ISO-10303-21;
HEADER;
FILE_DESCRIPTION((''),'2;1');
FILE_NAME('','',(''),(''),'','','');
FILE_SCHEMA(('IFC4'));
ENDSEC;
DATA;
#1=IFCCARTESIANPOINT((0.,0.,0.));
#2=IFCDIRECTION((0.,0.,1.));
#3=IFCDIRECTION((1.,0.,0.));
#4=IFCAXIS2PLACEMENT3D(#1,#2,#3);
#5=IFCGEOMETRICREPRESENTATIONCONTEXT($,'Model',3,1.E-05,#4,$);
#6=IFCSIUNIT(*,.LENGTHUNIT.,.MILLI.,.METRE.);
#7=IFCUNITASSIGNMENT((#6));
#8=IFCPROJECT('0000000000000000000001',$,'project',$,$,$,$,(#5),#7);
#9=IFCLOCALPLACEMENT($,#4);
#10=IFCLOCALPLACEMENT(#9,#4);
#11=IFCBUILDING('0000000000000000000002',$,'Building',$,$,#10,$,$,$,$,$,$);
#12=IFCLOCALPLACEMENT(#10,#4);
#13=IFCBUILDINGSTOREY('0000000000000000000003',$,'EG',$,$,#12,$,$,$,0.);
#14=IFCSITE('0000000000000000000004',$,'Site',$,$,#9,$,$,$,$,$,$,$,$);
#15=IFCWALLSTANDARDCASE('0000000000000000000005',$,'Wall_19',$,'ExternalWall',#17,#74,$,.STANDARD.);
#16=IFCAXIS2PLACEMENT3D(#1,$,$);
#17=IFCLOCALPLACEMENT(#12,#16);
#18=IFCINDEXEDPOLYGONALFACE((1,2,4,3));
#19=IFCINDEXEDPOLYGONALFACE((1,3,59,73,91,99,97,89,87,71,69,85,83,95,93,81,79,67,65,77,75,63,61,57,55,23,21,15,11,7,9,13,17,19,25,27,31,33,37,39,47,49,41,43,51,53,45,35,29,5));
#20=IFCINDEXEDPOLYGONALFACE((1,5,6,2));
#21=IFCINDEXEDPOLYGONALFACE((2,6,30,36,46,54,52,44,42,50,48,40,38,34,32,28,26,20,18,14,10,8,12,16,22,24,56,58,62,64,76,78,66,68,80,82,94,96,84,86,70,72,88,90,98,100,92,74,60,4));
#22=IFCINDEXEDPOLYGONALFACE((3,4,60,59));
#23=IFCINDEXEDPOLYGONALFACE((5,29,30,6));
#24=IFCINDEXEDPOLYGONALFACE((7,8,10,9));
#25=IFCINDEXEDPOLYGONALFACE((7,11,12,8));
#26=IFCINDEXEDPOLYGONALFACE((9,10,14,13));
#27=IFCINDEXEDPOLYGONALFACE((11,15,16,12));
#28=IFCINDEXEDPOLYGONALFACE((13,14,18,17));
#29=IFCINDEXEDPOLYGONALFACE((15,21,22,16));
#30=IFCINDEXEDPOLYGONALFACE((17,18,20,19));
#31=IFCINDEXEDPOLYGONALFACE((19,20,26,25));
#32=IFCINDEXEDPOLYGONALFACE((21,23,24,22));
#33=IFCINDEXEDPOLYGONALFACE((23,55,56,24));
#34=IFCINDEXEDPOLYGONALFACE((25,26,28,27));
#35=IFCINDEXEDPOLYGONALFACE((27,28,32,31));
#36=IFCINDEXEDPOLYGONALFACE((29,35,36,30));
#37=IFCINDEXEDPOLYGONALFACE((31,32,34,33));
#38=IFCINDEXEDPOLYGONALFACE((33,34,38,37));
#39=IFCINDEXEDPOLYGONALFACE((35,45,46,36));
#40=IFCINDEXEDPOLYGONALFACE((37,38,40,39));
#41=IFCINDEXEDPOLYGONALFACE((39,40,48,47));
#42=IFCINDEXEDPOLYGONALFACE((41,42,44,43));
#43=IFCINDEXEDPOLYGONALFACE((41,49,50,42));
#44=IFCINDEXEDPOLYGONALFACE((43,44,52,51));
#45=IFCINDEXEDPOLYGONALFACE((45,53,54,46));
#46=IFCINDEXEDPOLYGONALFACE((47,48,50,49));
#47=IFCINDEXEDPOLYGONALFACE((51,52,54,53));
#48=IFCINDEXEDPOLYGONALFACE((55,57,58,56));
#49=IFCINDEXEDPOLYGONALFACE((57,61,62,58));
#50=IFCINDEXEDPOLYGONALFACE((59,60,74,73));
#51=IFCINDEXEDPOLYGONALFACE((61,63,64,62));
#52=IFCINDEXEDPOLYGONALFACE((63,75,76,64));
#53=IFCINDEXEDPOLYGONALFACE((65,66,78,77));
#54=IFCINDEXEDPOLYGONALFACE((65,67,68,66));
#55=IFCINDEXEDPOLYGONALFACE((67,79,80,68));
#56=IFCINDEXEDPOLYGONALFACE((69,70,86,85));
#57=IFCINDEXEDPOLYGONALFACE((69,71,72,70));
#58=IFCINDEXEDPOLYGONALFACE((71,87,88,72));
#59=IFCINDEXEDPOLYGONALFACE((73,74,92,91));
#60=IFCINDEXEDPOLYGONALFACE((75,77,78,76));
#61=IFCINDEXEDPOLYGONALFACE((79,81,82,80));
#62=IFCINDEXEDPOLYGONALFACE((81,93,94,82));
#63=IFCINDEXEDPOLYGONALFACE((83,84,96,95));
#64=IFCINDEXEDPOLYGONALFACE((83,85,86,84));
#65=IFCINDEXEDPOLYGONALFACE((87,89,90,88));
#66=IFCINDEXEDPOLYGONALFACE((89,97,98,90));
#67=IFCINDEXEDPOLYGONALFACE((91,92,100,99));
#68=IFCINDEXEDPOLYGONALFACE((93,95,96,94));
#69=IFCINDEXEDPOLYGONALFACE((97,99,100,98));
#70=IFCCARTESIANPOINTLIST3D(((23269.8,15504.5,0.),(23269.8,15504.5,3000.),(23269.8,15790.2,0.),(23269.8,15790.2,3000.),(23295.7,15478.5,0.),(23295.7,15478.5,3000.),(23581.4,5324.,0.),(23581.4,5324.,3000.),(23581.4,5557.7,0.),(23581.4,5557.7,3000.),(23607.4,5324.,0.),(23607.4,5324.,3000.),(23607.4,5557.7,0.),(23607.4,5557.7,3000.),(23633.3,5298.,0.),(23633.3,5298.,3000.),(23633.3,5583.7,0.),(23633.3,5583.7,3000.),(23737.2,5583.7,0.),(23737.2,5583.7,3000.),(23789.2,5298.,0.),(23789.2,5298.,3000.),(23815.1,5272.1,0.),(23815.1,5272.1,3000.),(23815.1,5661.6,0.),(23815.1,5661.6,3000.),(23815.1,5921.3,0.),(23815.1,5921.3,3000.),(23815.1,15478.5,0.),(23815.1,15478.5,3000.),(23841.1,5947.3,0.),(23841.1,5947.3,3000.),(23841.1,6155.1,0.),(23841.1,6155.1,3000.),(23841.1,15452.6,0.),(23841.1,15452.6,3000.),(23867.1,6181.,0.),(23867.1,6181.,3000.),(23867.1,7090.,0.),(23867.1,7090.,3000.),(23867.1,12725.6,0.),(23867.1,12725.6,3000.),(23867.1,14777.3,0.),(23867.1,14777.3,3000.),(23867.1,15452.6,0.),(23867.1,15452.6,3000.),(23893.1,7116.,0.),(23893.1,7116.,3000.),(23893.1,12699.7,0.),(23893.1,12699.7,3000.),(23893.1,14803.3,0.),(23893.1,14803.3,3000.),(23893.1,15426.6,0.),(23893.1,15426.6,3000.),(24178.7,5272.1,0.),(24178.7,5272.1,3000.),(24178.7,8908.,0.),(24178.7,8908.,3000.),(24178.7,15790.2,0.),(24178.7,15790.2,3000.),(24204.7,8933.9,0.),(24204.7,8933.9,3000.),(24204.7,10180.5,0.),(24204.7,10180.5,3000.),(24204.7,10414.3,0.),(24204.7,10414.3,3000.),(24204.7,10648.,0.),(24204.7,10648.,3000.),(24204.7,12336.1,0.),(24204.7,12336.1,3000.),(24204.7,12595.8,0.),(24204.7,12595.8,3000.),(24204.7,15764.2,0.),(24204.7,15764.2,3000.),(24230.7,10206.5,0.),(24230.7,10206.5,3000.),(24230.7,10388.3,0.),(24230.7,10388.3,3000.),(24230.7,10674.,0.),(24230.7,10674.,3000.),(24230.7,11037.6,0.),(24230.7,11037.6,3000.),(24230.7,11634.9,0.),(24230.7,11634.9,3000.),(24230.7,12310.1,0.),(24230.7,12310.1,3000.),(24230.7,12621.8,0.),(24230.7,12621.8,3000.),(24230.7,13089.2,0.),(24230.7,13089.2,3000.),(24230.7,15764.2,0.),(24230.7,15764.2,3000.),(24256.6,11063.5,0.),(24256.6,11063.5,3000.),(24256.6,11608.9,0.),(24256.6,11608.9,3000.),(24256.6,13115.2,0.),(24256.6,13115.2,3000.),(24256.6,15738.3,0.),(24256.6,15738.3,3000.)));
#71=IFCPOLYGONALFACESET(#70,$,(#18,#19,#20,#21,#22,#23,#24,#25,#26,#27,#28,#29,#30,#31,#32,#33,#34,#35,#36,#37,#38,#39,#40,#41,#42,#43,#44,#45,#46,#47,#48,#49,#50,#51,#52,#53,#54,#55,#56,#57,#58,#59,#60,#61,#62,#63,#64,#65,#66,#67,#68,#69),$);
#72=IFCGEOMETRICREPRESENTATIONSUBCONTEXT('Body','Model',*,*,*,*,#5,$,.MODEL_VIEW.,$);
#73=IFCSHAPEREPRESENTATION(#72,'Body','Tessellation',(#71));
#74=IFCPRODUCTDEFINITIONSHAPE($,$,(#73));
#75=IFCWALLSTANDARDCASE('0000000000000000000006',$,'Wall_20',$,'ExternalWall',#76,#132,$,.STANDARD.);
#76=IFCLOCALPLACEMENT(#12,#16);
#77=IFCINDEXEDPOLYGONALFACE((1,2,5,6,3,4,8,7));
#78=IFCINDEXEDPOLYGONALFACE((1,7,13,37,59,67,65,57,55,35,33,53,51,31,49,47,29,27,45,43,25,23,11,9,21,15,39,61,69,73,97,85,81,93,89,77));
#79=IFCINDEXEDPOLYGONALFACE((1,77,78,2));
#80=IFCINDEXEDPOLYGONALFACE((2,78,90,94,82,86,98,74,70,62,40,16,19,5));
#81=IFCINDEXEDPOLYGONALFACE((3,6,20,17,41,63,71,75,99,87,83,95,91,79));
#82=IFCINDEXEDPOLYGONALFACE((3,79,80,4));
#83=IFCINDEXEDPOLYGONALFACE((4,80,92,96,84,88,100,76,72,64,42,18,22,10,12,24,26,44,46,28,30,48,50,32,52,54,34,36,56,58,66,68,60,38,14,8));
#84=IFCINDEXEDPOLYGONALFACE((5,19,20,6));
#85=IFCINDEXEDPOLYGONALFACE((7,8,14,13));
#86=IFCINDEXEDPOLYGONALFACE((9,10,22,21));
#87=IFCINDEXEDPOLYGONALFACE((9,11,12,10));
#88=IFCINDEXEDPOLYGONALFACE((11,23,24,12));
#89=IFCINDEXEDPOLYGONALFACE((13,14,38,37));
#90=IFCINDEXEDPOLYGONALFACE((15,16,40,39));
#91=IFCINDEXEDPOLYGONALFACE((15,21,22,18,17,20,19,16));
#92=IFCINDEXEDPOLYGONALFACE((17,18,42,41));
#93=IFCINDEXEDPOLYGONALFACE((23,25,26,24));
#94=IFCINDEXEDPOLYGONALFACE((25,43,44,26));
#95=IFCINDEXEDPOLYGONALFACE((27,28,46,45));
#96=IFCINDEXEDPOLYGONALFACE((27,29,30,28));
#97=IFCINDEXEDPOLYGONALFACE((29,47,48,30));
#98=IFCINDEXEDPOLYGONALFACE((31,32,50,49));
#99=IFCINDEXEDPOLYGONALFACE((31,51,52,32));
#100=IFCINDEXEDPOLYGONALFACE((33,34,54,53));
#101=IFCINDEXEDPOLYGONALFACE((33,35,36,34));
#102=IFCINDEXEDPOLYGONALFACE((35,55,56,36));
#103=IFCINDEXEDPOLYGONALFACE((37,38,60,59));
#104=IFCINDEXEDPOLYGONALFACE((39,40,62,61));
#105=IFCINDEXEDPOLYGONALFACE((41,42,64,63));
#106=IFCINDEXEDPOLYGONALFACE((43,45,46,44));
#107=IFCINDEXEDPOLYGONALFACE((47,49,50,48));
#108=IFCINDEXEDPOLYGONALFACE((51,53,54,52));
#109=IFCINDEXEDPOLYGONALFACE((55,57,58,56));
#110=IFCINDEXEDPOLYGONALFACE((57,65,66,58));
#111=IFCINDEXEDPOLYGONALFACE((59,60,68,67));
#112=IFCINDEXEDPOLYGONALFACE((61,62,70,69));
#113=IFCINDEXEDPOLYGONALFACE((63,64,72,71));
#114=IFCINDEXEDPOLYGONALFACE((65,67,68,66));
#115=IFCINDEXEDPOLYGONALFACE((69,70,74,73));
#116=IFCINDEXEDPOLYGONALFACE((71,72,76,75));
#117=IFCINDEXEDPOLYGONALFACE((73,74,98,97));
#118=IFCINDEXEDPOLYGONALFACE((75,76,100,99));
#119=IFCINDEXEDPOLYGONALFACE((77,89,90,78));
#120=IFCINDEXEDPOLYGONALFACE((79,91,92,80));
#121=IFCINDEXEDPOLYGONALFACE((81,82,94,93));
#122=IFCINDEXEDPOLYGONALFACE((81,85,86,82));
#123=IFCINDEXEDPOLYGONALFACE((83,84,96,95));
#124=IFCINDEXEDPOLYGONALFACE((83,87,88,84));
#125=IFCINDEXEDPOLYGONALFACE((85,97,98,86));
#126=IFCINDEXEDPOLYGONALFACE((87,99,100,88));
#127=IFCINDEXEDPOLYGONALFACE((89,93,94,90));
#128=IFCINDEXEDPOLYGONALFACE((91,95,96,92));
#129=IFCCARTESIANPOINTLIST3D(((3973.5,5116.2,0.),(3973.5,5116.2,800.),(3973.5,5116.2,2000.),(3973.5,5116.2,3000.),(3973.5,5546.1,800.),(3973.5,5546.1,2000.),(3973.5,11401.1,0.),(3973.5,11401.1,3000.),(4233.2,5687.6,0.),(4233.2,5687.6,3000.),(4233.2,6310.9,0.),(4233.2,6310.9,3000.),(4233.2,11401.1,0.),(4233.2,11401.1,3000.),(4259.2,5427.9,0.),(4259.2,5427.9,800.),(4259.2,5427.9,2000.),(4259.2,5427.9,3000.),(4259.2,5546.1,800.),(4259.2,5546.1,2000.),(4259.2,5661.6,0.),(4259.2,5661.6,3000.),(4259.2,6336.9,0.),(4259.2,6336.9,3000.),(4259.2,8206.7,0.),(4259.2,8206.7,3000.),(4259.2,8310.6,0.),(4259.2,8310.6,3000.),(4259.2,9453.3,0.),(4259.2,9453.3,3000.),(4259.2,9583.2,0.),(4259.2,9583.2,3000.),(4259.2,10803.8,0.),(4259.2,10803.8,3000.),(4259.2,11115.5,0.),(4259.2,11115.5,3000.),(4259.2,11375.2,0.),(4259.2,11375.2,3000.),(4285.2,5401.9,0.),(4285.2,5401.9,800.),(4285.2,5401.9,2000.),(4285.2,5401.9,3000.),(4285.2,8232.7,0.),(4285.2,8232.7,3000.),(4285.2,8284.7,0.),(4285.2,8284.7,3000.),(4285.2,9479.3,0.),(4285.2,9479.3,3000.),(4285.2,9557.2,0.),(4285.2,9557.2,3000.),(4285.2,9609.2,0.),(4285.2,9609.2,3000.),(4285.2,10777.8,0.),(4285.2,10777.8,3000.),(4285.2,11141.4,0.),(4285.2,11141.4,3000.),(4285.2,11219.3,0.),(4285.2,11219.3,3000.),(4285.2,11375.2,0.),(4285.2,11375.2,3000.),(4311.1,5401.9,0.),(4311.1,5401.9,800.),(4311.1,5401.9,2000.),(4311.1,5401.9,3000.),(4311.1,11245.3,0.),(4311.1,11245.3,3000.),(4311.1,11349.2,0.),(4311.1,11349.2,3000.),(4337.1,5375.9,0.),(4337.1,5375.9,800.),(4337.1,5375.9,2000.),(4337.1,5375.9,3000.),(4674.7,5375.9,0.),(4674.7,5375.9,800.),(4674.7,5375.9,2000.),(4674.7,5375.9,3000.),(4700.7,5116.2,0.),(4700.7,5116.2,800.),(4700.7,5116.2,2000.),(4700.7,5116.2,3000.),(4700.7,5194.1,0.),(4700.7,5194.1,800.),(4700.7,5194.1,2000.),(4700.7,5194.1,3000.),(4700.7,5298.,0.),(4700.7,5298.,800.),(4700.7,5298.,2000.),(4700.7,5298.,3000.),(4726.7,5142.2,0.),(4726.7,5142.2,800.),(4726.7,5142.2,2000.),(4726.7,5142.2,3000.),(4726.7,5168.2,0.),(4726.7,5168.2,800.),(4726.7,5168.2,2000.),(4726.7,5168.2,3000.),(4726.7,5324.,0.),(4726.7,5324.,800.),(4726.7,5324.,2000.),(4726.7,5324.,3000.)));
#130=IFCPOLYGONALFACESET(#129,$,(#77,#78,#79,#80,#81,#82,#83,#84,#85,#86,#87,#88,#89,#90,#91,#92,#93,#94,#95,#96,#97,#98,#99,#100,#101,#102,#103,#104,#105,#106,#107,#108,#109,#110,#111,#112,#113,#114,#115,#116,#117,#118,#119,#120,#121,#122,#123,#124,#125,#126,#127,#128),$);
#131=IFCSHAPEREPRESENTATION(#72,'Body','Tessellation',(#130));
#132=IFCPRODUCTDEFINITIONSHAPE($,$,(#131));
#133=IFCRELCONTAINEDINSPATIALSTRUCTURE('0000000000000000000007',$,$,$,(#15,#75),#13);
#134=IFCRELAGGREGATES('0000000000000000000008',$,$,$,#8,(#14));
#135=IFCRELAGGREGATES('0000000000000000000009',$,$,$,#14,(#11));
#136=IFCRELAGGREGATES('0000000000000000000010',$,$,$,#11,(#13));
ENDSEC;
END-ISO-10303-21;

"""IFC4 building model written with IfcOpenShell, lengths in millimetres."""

from ifc_helpers import new_model, si_unit, frame, origin_with_axes, place, context, subcontext, project, spatial, polyline, rectangle, outline, extrude, element, save


model = new_model("IFC4")

# Units and contexts
model_context = context("Model", 3, precision=1e-05, world=origin_with_axes())
body_context = subcontext(model_context, "Body", "Model", "MODEL_VIEW")
ifc_project = project(units=[si_unit("LENGTHUNIT", "METRE", prefix="MILLI")], contexts=[model_context])

# Site, building, storey
site_placement = place(None, origin_with_axes())
site = spatial("IfcSite", under=ifc_project, at=site_placement, Name="Site")
building_placement = place(site_placement, origin_with_axes())
building = spatial("IfcBuilding", under=site, at=building_placement, Name="Building")
storey_placement = place(building_placement, origin_with_axes())
storey = spatial("IfcBuildingStorey", under=building, at=storey_placement, Name="EG", Elevation=0.0)

# Wall
wall_1_placement = place(storey_placement, origin_with_axes())
element("IfcWallStandardCase", 1, at=wall_1_placement, inside=storey, Name="Wall_19", ObjectType="ExternalWall", PredefinedType="STANDARD", context=body_context, shape_type="SweptSolid", body=[
    extrude(outline(polyline([(23815.1, 5272.1, 0.0), (23789.2, 5298.0, 0.0), (23633.3, 5298.0, 0.0), (23607.4, 5324.0, 0.0), (23581.4, 5324.0, 0.0), (23581.4, 5557.7, 0.0), (23607.4, 5557.7, 0.0), (23633.3, 5583.7, 0.0), (23737.2, 5583.7, 0.0), (23815.1, 5661.6, 0.0), (23815.1, 5921.3, 0.0), (23841.1, 5947.3, 0.0), (23841.1, 6155.1, 0.0), (23867.1, 6181.0, 0.0), (23867.1, 7090.0, 0.0), (23893.1, 7116.0, 0.0), (23893.1, 12699.7, 0.0), (23867.1, 12725.6, 0.0), (23867.1, 14777.3, 0.0), (23893.1, 14803.3, 0.0), (23893.1, 15426.6, 0.0), (23867.1, 15452.6, 0.0), (23841.1, 15452.6, 0.0), (23815.1, 15478.5, 0.0), (23295.7, 15478.5, 0.0), (23269.8, 15504.5, 0.0), (23269.8, 15790.2, 0.0), (24178.7, 15790.2, 0.0), (24204.7, 15764.2, 0.0), (24230.7, 15764.2, 0.0), (24256.6, 15738.3, 0.0), (24256.6, 13115.2, 0.0), (24230.7, 13089.2, 0.0), (24230.7, 12621.8, 0.0), (24204.7, 12595.8, 0.0), (24204.7, 12336.1, 0.0), (24230.7, 12310.1, 0.0), (24230.7, 11634.9, 0.0), (24256.6, 11608.9, 0.0), (24256.6, 11063.5, 0.0), (24230.7, 11037.6, 0.0), (24230.7, 10674.0, 0.0), (24204.7, 10648.0, 0.0), (24204.7, 10414.3, 0.0), (24230.7, 10388.3, 0.0), (24230.7, 10206.5, 0.0), (24204.7, 10180.5, 0.0), (24204.7, 8933.9, 0.0), (24178.7, 8908.0, 0.0), (24178.7, 5272.1, 0.0), (23815.1, 5272.1, 0.0)])), origin_with_axes(), (0.0, 0.0, 1.0), 3000.0),
])

# Wall, opening
wall_2_placement = place(storey_placement, origin_with_axes())
wall_2 = element("IfcWallStandardCase", 2, at=wall_2_placement, inside=storey, Name="Wall_20", ObjectType="ExternalWall", PredefinedType="STANDARD", context=body_context, shape_type="SweptSolid", body=[
    extrude(outline(polyline([(3973.5, 5116.2, 0.0), (3973.5, 11401.1, 0.0), (4233.2, 11401.1, 0.0), (4259.2, 11375.2, 0.0), (4285.2, 11375.2, 0.0), (4311.1, 11349.2, 0.0), (4311.1, 11245.3, 0.0), (4285.2, 11219.3, 0.0), (4285.2, 11141.4, 0.0), (4259.2, 11115.5, 0.0), (4259.2, 10803.8, 0.0), (4285.2, 10777.8, 0.0), (4285.2, 9609.2, 0.0), (4259.2, 9583.2, 0.0), (4285.2, 9557.2, 0.0), (4285.2, 9479.3, 0.0), (4259.2, 9453.3, 0.0), (4259.2, 8310.6, 0.0), (4285.2, 8284.7, 0.0), (4285.2, 8232.7, 0.0), (4259.2, 8206.7, 0.0), (4259.2, 6336.9, 0.0), (4233.2, 6310.9, 0.0), (4233.2, 5687.6, 0.0), (4259.2, 5661.6, 0.0), (4259.2, 5427.9, 0.0), (4285.2, 5401.9, 0.0), (4311.1, 5401.9, 0.0), (4337.1, 5375.9, 0.0), (4674.7, 5375.9, 0.0), (4726.7, 5324.0, 0.0), (4700.7, 5298.0, 0.0), (4700.7, 5194.1, 0.0), (4726.7, 5168.2, 0.0), (4726.7, 5142.2, 0.0), (4700.7, 5116.2, 0.0), (3973.5, 5116.2, 0.0)])), origin_with_axes(), (0.0, 0.0, 1.0), 3000.0),
])
opening_1_placement = place(wall_2_placement, origin_with_axes())
element("IfcOpeningElement", 3, at=opening_1_placement, inside=storey, cuts=wall_2, context=body_context, shape_type="SweptSolid", body=[
    extrude(rectangle(XDim=600.0, YDim=753.2), frame((4350.1, 5246.1, 800.0), z_axis=(0.0, 0.0, 1.0), x_axis=(0.0, 1.0, 0.0)), (0.0, 0.0, 1.0), 1200.0),
])

save(model, "model.ifc")
